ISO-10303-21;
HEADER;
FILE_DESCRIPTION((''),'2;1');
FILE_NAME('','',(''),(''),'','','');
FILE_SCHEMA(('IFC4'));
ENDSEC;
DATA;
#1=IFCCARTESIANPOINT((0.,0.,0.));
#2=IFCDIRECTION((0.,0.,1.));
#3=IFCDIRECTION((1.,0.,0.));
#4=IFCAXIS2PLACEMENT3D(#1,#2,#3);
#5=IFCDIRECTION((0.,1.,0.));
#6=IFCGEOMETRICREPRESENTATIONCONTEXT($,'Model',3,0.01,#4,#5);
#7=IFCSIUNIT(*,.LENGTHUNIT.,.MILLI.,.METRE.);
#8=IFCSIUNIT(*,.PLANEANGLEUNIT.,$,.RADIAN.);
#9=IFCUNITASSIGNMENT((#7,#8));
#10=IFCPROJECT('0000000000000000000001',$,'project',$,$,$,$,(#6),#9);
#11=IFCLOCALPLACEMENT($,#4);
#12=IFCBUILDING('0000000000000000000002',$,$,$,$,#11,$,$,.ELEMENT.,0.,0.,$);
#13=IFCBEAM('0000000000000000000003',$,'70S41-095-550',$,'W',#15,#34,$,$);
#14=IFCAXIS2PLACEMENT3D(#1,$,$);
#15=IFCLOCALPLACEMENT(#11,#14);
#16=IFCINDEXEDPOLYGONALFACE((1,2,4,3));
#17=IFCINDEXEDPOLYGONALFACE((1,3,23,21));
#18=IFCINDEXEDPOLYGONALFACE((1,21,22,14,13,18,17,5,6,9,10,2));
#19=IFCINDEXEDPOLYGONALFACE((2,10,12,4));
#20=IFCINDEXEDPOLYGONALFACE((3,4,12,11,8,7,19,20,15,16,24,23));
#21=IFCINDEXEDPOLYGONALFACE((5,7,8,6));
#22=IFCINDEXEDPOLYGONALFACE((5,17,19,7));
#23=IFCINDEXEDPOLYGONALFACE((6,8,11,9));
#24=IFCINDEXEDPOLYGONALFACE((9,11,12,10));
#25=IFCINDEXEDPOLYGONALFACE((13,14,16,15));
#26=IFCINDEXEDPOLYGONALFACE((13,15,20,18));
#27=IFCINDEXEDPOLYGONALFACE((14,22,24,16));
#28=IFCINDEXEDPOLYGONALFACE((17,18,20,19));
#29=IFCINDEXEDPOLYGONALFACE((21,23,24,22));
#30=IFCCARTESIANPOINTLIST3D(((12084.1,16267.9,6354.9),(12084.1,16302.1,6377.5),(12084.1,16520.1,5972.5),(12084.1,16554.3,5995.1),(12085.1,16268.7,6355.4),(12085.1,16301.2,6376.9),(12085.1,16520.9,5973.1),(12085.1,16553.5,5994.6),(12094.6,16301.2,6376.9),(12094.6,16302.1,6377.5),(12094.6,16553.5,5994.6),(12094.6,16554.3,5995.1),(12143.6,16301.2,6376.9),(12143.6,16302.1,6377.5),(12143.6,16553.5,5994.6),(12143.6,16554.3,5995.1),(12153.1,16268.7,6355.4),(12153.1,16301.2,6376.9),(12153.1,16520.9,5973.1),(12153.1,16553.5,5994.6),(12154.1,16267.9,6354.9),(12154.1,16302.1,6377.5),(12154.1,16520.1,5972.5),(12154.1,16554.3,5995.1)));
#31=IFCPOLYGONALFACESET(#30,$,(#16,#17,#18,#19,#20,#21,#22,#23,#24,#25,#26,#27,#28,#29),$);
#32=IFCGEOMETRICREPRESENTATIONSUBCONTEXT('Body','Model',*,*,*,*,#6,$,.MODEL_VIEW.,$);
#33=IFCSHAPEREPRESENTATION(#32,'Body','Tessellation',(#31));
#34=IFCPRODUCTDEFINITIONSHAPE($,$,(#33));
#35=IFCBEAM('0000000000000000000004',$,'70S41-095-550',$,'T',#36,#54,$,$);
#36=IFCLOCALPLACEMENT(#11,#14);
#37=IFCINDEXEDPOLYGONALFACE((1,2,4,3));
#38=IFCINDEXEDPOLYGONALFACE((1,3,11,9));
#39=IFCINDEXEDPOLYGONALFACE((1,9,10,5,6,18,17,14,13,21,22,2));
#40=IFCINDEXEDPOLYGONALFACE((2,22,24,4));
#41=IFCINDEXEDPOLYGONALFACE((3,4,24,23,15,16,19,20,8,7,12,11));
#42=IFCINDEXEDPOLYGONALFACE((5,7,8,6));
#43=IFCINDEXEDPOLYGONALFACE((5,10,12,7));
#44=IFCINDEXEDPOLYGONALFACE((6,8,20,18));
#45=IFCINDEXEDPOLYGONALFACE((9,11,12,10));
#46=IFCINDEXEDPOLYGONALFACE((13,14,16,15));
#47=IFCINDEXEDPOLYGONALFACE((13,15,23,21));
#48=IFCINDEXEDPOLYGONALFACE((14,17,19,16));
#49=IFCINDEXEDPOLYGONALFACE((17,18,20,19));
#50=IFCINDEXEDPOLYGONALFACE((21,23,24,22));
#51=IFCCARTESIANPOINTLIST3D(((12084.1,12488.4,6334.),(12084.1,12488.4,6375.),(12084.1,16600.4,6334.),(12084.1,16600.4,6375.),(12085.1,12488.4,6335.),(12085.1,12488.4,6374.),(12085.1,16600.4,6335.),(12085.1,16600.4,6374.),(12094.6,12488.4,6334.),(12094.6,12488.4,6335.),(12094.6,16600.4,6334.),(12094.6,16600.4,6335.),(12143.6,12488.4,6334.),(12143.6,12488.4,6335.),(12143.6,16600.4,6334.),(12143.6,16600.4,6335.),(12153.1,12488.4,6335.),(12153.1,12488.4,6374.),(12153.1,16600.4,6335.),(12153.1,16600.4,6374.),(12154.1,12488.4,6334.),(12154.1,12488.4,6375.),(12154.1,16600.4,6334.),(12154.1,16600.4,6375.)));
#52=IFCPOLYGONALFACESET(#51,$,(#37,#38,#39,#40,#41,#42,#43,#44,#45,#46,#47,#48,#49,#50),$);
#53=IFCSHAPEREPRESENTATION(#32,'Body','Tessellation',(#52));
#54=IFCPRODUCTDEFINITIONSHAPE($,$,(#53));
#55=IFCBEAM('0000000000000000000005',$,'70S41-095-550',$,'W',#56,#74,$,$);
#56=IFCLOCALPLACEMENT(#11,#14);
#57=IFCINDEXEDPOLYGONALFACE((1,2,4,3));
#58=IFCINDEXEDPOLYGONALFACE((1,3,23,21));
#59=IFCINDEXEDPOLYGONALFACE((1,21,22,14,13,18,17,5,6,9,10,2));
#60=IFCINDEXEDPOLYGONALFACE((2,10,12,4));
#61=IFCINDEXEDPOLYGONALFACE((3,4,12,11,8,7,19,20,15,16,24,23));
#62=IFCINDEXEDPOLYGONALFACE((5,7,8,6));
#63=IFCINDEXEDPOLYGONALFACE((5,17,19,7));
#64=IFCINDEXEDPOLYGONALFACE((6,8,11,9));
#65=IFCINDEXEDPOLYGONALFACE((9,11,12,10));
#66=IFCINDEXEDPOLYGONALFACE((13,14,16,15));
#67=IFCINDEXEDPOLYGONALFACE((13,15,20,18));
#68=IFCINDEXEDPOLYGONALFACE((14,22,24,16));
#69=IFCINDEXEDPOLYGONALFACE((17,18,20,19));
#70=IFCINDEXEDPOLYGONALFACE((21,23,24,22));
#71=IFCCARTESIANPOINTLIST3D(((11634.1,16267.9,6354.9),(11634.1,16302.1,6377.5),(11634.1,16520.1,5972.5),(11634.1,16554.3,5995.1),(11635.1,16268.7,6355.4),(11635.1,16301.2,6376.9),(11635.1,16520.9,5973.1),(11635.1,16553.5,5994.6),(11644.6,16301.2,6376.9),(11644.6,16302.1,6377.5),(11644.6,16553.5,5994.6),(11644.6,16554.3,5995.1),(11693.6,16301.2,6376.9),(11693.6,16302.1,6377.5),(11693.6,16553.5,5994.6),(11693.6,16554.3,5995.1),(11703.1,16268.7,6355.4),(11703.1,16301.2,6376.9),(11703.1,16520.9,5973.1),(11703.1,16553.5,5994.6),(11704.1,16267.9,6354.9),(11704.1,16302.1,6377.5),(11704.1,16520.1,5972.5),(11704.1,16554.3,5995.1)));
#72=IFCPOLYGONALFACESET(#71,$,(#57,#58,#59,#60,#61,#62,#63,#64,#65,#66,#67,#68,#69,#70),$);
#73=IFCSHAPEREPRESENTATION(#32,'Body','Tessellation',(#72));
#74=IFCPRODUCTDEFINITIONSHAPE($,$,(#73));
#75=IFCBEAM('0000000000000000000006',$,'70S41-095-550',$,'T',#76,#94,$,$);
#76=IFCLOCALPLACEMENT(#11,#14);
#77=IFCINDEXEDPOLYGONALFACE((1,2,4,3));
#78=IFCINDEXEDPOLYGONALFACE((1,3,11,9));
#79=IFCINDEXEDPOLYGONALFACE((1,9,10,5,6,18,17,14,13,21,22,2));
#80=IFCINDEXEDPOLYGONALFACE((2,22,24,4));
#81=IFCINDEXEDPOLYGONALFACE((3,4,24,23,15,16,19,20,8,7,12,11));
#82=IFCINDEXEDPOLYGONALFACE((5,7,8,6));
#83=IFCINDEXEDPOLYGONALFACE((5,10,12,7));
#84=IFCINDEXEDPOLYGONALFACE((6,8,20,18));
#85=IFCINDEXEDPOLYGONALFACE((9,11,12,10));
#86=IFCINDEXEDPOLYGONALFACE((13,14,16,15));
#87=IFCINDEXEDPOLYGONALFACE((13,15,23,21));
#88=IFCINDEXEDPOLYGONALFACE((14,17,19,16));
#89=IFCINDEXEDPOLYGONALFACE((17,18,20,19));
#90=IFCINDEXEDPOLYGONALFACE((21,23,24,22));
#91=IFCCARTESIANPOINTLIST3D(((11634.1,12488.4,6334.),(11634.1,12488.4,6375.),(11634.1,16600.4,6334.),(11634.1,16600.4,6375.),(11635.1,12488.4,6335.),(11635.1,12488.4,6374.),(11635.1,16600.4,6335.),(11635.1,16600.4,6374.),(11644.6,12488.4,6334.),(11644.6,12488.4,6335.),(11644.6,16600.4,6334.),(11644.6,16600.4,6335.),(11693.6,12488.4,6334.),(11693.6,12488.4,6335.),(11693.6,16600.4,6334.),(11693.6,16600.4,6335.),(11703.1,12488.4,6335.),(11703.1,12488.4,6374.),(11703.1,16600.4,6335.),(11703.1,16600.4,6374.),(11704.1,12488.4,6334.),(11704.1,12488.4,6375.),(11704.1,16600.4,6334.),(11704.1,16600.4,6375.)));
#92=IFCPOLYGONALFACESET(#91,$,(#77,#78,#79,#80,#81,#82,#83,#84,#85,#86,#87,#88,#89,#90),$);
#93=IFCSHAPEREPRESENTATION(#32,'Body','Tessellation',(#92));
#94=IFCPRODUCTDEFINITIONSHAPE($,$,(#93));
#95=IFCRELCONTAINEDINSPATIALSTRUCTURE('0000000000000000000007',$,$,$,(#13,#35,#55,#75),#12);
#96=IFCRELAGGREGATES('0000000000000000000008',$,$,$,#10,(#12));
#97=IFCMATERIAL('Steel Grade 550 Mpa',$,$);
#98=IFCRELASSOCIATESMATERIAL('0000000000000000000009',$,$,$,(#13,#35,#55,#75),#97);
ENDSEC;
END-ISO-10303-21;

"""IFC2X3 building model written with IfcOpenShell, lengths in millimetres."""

from ifc_helpers import new_model, si_unit, direction, frame, origin, origin_with_axes, origin_2d_with_axis, place, context, subcontext, project, spatial, c_section, extrude, source, transform, mapped, material, element, save


model = new_model("IFC2X3")

# Units and contexts
model_context = context("Model", 3, precision=0.01, world=origin_with_axes(), true_north=direction((0.0, 1.0, 0.0)))
body_context = subcontext(model_context, "Body", "Model", "MODEL_VIEW")
ifc_project = project(units=[si_unit("LENGTHUNIT", "METRE", prefix="MILLI"), si_unit("PLANEANGLEUNIT", "RADIAN")], contexts=[model_context])

# Building
building_placement = place(None, origin_with_axes())
building = spatial("IfcBuilding", under=ifc_project, at=building_placement, CompositionType="ELEMENT", ElevationOfRefHeight=0.0, ElevationOfTerrain=0.0)

# Shared definitions
ifc_material = material(Name="Steel Grade 550 Mpa")

# Beams
shared_shape_1 = source(origin(), body_context, "Body", "SweptSolid", [
    extrude(c_section(Depth=70.0, Width=41.0, WallThickness=1.0, Girth=10.5, at=origin_2d_with_axis()), origin_with_axes(), (0.0, 0.0, 1.0), 458.1),
])
beam_1_placement = place(None, frame((12119.1, 16285.0, 6366.2), z_axis=(0.0, 0.550611, -0.834762), x_axis=(0.0, 0.834762, 0.550611)))
element("IfcBeam", 1, at=beam_1_placement, inside=building, material=ifc_material, Name="70S41-095-550", ObjectType="W", context=body_context, shape_type="MappedRepresentation", body=[
    mapped(shared_shape_1, transform((0.0, 0.0, 0.0), scale=1.0)),
])
shared_shape_2 = source(origin(), body_context, "Body", "SweptSolid", [
    extrude(c_section(Depth=70.0, Width=41.0, WallThickness=1.0, Girth=10.5, at=origin_2d_with_axis()), origin_with_axes(), (0.0, 0.0, 1.0), 4112.0),
])
beam_2_placement = place(None, frame((12119.1, 16600.4, 6354.5), z_axis=(0.0, -1.0, 0.0), x_axis=(0.0, 0.0, -1.0)))
element("IfcBeam", 2, at=beam_2_placement, inside=building, material=ifc_material, Name="70S41-095-550", ObjectType="T", context=body_context, shape_type="MappedRepresentation", body=[
    mapped(shared_shape_2, transform((0.0, 0.0, 0.0), scale=1.0)),
])
shared_shape_3 = source(origin(), body_context, "Body", "SweptSolid", [
    extrude(c_section(Depth=70.0, Width=41.0, WallThickness=1.0, Girth=10.5, at=origin_2d_with_axis()), origin_with_axes(), (0.0, 0.0, 1.0), 458.1),
])
beam_3_placement = place(None, frame((11669.1, 16285.0, 6366.2), z_axis=(0.0, 0.550611, -0.834762), x_axis=(0.0, 0.834762, 0.550611)))
element("IfcBeam", 3, at=beam_3_placement, inside=building, material=ifc_material, Name="70S41-095-550", ObjectType="W", context=body_context, shape_type="MappedRepresentation", body=[
    mapped(shared_shape_3, transform((0.0, 0.0, 0.0), scale=1.0)),
])
shared_shape_4 = source(origin(), body_context, "Body", "SweptSolid", [
    extrude(c_section(Depth=70.0, Width=41.0, WallThickness=1.0, Girth=10.5, at=origin_2d_with_axis()), origin_with_axes(), (0.0, 0.0, 1.0), 4112.0),
])
beam_4_placement = place(None, frame((11669.1, 16600.4, 6354.5), z_axis=(0.0, -1.0, 0.0), x_axis=(0.0, 0.0, -1.0)))
element("IfcBeam", 4, at=beam_4_placement, inside=building, material=ifc_material, Name="70S41-095-550", ObjectType="T", context=body_context, shape_type="MappedRepresentation", body=[
    mapped(shared_shape_4, transform((0.0, 0.0, 0.0), scale=1.0)),
])

save(model, "model.ifc")
